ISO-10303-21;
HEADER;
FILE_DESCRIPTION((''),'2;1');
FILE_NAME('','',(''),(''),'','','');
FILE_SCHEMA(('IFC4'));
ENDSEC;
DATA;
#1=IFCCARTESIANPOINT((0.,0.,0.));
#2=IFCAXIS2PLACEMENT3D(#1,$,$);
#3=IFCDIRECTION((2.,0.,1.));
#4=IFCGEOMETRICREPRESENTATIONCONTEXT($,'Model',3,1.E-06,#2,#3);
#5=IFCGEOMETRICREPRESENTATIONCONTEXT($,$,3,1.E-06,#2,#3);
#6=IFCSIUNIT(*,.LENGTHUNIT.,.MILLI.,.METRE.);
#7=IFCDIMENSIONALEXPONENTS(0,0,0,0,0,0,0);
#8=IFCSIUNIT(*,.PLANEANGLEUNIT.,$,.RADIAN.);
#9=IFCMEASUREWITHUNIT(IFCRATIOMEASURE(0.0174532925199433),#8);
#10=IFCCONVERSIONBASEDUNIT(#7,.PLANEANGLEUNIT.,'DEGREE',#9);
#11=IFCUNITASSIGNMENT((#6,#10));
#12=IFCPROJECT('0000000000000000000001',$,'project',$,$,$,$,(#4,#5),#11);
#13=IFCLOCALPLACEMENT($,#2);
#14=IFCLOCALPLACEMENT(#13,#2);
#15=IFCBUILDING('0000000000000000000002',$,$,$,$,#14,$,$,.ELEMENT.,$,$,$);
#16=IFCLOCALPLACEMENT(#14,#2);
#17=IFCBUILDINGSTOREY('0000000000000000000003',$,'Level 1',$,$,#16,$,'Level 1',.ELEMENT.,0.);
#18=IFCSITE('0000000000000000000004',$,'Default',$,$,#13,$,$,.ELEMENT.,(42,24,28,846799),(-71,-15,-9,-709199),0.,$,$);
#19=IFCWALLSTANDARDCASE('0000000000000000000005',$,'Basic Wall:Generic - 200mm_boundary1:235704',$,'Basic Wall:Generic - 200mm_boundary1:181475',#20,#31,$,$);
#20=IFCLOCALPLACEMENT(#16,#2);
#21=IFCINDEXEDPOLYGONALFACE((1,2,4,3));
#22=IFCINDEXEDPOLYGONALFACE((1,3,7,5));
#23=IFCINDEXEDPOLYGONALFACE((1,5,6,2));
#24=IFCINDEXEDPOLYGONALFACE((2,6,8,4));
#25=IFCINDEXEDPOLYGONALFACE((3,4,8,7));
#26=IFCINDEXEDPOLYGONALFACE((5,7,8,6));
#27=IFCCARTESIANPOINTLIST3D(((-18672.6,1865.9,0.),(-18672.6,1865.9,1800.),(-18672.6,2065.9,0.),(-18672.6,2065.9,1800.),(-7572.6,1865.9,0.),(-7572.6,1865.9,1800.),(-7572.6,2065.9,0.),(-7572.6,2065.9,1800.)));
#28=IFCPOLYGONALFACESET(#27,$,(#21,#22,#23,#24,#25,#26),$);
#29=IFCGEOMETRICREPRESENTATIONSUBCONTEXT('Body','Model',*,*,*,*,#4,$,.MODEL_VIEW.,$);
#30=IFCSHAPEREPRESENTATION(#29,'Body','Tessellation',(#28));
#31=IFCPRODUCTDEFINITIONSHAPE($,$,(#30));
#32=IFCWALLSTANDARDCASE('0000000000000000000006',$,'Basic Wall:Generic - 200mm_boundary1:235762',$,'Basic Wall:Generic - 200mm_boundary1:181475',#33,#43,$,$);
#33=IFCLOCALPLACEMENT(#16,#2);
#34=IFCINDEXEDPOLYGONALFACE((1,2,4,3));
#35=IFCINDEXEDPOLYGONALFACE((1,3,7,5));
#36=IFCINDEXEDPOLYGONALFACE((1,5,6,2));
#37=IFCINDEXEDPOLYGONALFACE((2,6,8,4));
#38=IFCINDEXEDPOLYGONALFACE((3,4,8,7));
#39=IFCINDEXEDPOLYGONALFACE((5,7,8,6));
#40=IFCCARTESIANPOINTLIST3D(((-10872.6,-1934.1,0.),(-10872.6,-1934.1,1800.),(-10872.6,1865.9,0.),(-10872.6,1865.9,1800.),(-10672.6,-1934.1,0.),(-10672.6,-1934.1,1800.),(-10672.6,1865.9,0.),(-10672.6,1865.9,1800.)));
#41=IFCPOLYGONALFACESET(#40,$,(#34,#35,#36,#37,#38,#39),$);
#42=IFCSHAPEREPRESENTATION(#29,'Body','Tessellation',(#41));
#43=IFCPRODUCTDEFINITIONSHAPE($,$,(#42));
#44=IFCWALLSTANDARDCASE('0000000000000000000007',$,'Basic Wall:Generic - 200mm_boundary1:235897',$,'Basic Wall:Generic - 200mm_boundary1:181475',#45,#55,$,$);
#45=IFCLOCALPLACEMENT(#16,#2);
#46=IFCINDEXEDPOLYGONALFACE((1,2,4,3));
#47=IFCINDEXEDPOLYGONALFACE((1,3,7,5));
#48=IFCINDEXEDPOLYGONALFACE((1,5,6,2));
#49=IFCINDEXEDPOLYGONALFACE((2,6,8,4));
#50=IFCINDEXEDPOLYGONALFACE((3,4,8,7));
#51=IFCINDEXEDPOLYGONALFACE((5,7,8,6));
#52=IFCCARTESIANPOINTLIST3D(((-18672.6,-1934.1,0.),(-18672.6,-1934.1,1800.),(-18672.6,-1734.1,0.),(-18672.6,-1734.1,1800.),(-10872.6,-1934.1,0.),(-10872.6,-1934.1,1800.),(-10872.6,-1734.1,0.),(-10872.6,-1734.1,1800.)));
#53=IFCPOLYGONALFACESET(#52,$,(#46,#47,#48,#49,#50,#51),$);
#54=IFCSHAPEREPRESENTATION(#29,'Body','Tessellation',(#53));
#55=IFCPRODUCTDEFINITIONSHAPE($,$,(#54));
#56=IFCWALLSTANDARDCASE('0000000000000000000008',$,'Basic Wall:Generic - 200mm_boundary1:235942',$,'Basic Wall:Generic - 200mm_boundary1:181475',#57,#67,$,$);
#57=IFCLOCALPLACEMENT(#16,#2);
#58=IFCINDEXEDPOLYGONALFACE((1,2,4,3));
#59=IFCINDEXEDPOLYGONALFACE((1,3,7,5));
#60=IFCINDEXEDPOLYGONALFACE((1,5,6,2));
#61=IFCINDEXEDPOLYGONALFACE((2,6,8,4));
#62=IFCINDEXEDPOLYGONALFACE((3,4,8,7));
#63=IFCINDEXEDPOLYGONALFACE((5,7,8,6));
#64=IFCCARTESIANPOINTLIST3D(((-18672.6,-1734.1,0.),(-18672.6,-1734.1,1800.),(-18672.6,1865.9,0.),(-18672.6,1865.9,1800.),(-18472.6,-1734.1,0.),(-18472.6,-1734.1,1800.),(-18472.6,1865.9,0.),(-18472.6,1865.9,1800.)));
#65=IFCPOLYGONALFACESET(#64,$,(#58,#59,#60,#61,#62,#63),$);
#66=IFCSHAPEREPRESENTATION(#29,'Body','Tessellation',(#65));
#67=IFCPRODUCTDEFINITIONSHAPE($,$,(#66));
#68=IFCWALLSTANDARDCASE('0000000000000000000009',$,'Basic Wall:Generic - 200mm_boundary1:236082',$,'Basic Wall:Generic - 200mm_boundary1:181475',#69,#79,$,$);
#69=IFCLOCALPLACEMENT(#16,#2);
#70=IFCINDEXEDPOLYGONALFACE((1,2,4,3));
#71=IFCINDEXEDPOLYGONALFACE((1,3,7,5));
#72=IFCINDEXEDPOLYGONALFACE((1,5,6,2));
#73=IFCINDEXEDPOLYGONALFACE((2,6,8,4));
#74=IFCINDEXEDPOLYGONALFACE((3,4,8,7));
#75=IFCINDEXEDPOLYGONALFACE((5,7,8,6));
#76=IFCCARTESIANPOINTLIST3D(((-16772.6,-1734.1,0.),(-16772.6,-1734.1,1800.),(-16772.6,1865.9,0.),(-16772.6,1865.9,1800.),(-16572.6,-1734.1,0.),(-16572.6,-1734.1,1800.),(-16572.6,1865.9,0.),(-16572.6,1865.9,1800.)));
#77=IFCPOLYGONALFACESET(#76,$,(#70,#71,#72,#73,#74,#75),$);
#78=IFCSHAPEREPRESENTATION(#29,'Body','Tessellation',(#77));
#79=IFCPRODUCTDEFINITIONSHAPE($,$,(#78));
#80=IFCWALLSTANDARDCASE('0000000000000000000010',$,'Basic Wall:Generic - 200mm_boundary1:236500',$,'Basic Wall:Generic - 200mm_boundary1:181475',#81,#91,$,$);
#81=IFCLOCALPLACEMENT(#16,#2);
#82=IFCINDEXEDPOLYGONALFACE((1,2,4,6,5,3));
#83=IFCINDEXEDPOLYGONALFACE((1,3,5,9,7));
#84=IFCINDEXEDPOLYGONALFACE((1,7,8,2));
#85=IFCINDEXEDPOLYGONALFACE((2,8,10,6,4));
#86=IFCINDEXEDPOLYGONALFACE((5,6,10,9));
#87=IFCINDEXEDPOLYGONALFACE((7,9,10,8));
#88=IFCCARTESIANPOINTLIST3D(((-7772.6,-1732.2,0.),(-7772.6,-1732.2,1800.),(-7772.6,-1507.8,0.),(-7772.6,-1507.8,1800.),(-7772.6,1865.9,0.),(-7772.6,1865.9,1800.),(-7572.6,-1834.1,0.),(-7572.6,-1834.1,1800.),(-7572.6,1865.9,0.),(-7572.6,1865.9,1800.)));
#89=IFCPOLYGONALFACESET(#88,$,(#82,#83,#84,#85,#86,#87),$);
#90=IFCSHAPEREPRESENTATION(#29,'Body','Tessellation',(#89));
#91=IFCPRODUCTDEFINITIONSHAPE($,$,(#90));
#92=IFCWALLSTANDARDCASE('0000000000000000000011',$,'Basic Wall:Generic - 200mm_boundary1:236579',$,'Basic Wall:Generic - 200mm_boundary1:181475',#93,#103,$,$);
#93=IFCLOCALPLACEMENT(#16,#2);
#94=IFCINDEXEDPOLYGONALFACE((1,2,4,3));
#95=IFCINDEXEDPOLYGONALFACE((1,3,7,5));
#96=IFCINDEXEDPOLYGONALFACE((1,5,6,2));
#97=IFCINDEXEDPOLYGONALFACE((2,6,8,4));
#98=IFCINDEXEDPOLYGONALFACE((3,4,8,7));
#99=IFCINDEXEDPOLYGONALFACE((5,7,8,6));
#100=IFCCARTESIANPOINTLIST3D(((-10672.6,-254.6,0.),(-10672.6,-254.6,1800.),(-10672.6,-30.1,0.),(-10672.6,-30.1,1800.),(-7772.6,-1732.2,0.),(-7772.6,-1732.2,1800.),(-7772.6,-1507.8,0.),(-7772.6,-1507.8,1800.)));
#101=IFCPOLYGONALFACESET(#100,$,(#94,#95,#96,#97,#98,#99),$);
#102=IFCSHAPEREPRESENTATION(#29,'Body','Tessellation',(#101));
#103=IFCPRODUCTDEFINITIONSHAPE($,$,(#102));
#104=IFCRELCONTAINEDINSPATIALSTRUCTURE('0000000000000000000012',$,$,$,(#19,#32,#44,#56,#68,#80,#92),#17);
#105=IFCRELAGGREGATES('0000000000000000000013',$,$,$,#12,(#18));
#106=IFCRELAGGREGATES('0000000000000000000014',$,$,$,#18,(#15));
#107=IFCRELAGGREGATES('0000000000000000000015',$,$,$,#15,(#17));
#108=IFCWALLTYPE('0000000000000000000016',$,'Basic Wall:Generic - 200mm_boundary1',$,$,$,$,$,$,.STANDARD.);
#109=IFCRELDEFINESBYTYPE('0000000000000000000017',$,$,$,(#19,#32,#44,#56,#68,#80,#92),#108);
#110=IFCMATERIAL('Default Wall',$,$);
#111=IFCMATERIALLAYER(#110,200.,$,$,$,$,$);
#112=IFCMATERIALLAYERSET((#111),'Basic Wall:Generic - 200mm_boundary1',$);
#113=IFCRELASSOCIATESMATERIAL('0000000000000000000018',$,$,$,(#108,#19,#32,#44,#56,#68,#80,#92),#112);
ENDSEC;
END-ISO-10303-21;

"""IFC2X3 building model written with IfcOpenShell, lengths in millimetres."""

from ifc_helpers import new_model, entity, si_unit, converted_unit, direction, frame, frame_2d, origin, place, context, subcontext, project, spatial, polyline, rectangle, outline, extrude, material, layer, layer_set, layer_usage, type_object, element, save


model = new_model("IFC2X3")

# Units and contexts
model_context = context("Model", 3, precision=1e-06, world=origin(), true_north=direction((2.0, 0.0, 1.0)))
context_of_model = context(None, 3, precision=1e-06, world=origin(), true_north=direction((2.0, 0.0, 1.0)))
body_context = subcontext(model_context, "Body", "Model", "MODEL_VIEW")
ifc_project = project(units=[si_unit("LENGTHUNIT", "METRE", prefix="MILLI"), converted_unit("PLANEANGLEUNIT", "DEGREE", entity("IfcRatioMeasure", 0.0174532925199433), si_unit("PLANEANGLEUNIT", "RADIAN"), dimensions=[0, 0, 0, 0, 0, 0, 0])], contexts=[model_context, context_of_model])

# Site, building, storey
site_placement = place(None, origin())
site = spatial("IfcSite", under=ifc_project, at=site_placement, Name="Default", CompositionType="ELEMENT", RefLatitude=(42, 24, 28, 846799), RefLongitude=(-71, -15, -9, -709199), RefElevation=0.0)
building_placement = place(site_placement, origin())
building = spatial("IfcBuilding", under=site, at=building_placement, CompositionType="ELEMENT")
storey_placement = place(building_placement, origin())
storey = spatial("IfcBuildingStorey", under=building, at=storey_placement, Name="Level 1", LongName="Level 1", CompositionType="ELEMENT", Elevation=0.0)

# Walls
ifc_material = material(Name="Default Wall")
ifc_layer = layer(ifc_material, 200.0)
ifc_layer_set = layer_set([ifc_layer], Name="Basic Wall:Generic - 200mm_boundary1")
ifc_layer_usage_1 = layer_usage(ifc_layer_set, "AXIS2", "NEGATIVE", 100.0)
wall_type = type_object("IfcWallType", Name="Basic Wall:Generic - 200mm_boundary1", PredefinedType="STANDARD", material=ifc_layer_set)
wall_1_placement = place(storey_placement, frame((-18672.6, 1965.9, 0.0)))
element("IfcWallStandardCase", 1, at=wall_1_placement, inside=storey, type_object=wall_type, material=ifc_layer_usage_1, Name="Basic Wall:Generic - 200mm_boundary1:235704", ObjectType="Basic Wall:Generic - 200mm_boundary1:181475", context=body_context, shape_type="SweptSolid", body=[
    extrude(rectangle(XDim=11100.0, YDim=200.0, at=frame_2d((5550.0, 0.0), x_axis=(-1.0, 0.0))), origin(), (0.0, 0.0, 1.0), 1800.0),
])
ifc_layer_usage_2 = layer_usage(ifc_layer_set, "AXIS2", "NEGATIVE", 100.0)
wall_2_placement = place(storey_placement, frame((-10772.6, 1865.9, 0.0), z_axis=(0.0, 0.0, 1.0), x_axis=(0.0, -1.0, 0.0)))
element("IfcWallStandardCase", 2, at=wall_2_placement, inside=storey, type_object=wall_type, material=ifc_layer_usage_2, Name="Basic Wall:Generic - 200mm_boundary1:235762", ObjectType="Basic Wall:Generic - 200mm_boundary1:181475", context=body_context, shape_type="SweptSolid", body=[
    extrude(rectangle(XDim=3800.0, YDim=200.0, at=frame_2d((1900.0, 0.0), x_axis=(-1.0, 0.0))), origin(), (0.0, 0.0, 1.0), 1800.0),
])
ifc_layer_usage_3 = layer_usage(ifc_layer_set, "AXIS2", "NEGATIVE", 100.0)
wall_3_placement = place(storey_placement, frame((-10872.6, -1834.1, 0.0), z_axis=(0.0, 0.0, 1.0), x_axis=(-1.0, 0.0, 0.0)))
element("IfcWallStandardCase", 3, at=wall_3_placement, inside=storey, type_object=wall_type, material=ifc_layer_usage_3, Name="Basic Wall:Generic - 200mm_boundary1:235897", ObjectType="Basic Wall:Generic - 200mm_boundary1:181475", context=body_context, shape_type="SweptSolid", body=[
    extrude(rectangle(XDim=7800.0, YDim=200.0, at=frame_2d((3900.0, 0.0), x_axis=(-1.0, 0.0))), origin(), (0.0, 0.0, 1.0), 1800.0),
])
ifc_layer_usage_4 = layer_usage(ifc_layer_set, "AXIS2", "NEGATIVE", 100.0)
wall_4_placement = place(storey_placement, frame((-18572.6, -1734.1, 0.0), z_axis=(0.0, 0.0, 1.0), x_axis=(0.0, 1.0, 0.0)))
element("IfcWallStandardCase", 4, at=wall_4_placement, inside=storey, type_object=wall_type, material=ifc_layer_usage_4, Name="Basic Wall:Generic - 200mm_boundary1:235942", ObjectType="Basic Wall:Generic - 200mm_boundary1:181475", context=body_context, shape_type="SweptSolid", body=[
    extrude(rectangle(XDim=3600.0, YDim=200.0, at=frame_2d((1800.0, 0.0), x_axis=(-1.0, 0.0))), origin(), (0.0, 0.0, 1.0), 1800.0),
])
ifc_layer_usage_5 = layer_usage(ifc_layer_set, "AXIS2", "NEGATIVE", 100.0)
wall_5_placement = place(storey_placement, frame((-16672.6, 1865.9, 0.0), z_axis=(0.0, 0.0, 1.0), x_axis=(0.0, -1.0, 0.0)))
element("IfcWallStandardCase", 5, at=wall_5_placement, inside=storey, type_object=wall_type, material=ifc_layer_usage_5, Name="Basic Wall:Generic - 200mm_boundary1:236082", ObjectType="Basic Wall:Generic - 200mm_boundary1:181475", context=body_context, shape_type="SweptSolid", body=[
    extrude(rectangle(XDim=3600.0, YDim=200.0, at=frame_2d((1800.0, 0.0), x_axis=(-1.0, 0.0))), origin(), (0.0, 0.0, 1.0), 1800.0),
])
ifc_layer_usage_6 = layer_usage(ifc_layer_set, "AXIS2", "NEGATIVE", 100.0)
wall_6_placement = place(storey_placement, frame((-7672.6, 1865.9, 0.0), z_axis=(0.0, 0.0, 1.0), x_axis=(0.0, -1.0, 0.0)))
element("IfcWallStandardCase", 6, at=wall_6_placement, inside=storey, type_object=wall_type, material=ifc_layer_usage_6, Name="Basic Wall:Generic - 200mm_boundary1:236500", ObjectType="Basic Wall:Generic - 200mm_boundary1:181475", context=body_context, shape_type="SweptSolid", body=[
    extrude(outline(polyline([(3598.1, -100.0), (3700.0, 100.0), (0.0, 100.0), (0.0, -100.0), (3373.6, -100.0), (3598.1, -100.0)])), origin(), (0.0, 0.0, 1.0), 1800.0),
])
ifc_layer_usage_7 = layer_usage(ifc_layer_set, "AXIS2", "NEGATIVE", 100.0)
wall_7_placement = place(storey_placement, frame((-7727.2, -1643.1, 0.0), z_axis=(0.0, 0.0, 1.0), x_axis=(-0.891007, 0.45399, 0.0)))
element("IfcWallStandardCase", 7, at=wall_7_placement, inside=storey, type_object=wall_type, material=ifc_layer_usage_7, Name="Basic Wall:Generic - 200mm_boundary1:236579", ObjectType="Basic Wall:Generic - 200mm_boundary1:181475", context=body_context, shape_type="SweptSolid", body=[
    extrude(outline(polyline([(3356.7, -100.0), (3254.7, 100.0), (0.0, 100.0), (101.9, -100.0), (3356.7, -100.0)])), origin(), (0.0, 0.0, 1.0), 1800.0),
])

save(model, "model.ifc")
